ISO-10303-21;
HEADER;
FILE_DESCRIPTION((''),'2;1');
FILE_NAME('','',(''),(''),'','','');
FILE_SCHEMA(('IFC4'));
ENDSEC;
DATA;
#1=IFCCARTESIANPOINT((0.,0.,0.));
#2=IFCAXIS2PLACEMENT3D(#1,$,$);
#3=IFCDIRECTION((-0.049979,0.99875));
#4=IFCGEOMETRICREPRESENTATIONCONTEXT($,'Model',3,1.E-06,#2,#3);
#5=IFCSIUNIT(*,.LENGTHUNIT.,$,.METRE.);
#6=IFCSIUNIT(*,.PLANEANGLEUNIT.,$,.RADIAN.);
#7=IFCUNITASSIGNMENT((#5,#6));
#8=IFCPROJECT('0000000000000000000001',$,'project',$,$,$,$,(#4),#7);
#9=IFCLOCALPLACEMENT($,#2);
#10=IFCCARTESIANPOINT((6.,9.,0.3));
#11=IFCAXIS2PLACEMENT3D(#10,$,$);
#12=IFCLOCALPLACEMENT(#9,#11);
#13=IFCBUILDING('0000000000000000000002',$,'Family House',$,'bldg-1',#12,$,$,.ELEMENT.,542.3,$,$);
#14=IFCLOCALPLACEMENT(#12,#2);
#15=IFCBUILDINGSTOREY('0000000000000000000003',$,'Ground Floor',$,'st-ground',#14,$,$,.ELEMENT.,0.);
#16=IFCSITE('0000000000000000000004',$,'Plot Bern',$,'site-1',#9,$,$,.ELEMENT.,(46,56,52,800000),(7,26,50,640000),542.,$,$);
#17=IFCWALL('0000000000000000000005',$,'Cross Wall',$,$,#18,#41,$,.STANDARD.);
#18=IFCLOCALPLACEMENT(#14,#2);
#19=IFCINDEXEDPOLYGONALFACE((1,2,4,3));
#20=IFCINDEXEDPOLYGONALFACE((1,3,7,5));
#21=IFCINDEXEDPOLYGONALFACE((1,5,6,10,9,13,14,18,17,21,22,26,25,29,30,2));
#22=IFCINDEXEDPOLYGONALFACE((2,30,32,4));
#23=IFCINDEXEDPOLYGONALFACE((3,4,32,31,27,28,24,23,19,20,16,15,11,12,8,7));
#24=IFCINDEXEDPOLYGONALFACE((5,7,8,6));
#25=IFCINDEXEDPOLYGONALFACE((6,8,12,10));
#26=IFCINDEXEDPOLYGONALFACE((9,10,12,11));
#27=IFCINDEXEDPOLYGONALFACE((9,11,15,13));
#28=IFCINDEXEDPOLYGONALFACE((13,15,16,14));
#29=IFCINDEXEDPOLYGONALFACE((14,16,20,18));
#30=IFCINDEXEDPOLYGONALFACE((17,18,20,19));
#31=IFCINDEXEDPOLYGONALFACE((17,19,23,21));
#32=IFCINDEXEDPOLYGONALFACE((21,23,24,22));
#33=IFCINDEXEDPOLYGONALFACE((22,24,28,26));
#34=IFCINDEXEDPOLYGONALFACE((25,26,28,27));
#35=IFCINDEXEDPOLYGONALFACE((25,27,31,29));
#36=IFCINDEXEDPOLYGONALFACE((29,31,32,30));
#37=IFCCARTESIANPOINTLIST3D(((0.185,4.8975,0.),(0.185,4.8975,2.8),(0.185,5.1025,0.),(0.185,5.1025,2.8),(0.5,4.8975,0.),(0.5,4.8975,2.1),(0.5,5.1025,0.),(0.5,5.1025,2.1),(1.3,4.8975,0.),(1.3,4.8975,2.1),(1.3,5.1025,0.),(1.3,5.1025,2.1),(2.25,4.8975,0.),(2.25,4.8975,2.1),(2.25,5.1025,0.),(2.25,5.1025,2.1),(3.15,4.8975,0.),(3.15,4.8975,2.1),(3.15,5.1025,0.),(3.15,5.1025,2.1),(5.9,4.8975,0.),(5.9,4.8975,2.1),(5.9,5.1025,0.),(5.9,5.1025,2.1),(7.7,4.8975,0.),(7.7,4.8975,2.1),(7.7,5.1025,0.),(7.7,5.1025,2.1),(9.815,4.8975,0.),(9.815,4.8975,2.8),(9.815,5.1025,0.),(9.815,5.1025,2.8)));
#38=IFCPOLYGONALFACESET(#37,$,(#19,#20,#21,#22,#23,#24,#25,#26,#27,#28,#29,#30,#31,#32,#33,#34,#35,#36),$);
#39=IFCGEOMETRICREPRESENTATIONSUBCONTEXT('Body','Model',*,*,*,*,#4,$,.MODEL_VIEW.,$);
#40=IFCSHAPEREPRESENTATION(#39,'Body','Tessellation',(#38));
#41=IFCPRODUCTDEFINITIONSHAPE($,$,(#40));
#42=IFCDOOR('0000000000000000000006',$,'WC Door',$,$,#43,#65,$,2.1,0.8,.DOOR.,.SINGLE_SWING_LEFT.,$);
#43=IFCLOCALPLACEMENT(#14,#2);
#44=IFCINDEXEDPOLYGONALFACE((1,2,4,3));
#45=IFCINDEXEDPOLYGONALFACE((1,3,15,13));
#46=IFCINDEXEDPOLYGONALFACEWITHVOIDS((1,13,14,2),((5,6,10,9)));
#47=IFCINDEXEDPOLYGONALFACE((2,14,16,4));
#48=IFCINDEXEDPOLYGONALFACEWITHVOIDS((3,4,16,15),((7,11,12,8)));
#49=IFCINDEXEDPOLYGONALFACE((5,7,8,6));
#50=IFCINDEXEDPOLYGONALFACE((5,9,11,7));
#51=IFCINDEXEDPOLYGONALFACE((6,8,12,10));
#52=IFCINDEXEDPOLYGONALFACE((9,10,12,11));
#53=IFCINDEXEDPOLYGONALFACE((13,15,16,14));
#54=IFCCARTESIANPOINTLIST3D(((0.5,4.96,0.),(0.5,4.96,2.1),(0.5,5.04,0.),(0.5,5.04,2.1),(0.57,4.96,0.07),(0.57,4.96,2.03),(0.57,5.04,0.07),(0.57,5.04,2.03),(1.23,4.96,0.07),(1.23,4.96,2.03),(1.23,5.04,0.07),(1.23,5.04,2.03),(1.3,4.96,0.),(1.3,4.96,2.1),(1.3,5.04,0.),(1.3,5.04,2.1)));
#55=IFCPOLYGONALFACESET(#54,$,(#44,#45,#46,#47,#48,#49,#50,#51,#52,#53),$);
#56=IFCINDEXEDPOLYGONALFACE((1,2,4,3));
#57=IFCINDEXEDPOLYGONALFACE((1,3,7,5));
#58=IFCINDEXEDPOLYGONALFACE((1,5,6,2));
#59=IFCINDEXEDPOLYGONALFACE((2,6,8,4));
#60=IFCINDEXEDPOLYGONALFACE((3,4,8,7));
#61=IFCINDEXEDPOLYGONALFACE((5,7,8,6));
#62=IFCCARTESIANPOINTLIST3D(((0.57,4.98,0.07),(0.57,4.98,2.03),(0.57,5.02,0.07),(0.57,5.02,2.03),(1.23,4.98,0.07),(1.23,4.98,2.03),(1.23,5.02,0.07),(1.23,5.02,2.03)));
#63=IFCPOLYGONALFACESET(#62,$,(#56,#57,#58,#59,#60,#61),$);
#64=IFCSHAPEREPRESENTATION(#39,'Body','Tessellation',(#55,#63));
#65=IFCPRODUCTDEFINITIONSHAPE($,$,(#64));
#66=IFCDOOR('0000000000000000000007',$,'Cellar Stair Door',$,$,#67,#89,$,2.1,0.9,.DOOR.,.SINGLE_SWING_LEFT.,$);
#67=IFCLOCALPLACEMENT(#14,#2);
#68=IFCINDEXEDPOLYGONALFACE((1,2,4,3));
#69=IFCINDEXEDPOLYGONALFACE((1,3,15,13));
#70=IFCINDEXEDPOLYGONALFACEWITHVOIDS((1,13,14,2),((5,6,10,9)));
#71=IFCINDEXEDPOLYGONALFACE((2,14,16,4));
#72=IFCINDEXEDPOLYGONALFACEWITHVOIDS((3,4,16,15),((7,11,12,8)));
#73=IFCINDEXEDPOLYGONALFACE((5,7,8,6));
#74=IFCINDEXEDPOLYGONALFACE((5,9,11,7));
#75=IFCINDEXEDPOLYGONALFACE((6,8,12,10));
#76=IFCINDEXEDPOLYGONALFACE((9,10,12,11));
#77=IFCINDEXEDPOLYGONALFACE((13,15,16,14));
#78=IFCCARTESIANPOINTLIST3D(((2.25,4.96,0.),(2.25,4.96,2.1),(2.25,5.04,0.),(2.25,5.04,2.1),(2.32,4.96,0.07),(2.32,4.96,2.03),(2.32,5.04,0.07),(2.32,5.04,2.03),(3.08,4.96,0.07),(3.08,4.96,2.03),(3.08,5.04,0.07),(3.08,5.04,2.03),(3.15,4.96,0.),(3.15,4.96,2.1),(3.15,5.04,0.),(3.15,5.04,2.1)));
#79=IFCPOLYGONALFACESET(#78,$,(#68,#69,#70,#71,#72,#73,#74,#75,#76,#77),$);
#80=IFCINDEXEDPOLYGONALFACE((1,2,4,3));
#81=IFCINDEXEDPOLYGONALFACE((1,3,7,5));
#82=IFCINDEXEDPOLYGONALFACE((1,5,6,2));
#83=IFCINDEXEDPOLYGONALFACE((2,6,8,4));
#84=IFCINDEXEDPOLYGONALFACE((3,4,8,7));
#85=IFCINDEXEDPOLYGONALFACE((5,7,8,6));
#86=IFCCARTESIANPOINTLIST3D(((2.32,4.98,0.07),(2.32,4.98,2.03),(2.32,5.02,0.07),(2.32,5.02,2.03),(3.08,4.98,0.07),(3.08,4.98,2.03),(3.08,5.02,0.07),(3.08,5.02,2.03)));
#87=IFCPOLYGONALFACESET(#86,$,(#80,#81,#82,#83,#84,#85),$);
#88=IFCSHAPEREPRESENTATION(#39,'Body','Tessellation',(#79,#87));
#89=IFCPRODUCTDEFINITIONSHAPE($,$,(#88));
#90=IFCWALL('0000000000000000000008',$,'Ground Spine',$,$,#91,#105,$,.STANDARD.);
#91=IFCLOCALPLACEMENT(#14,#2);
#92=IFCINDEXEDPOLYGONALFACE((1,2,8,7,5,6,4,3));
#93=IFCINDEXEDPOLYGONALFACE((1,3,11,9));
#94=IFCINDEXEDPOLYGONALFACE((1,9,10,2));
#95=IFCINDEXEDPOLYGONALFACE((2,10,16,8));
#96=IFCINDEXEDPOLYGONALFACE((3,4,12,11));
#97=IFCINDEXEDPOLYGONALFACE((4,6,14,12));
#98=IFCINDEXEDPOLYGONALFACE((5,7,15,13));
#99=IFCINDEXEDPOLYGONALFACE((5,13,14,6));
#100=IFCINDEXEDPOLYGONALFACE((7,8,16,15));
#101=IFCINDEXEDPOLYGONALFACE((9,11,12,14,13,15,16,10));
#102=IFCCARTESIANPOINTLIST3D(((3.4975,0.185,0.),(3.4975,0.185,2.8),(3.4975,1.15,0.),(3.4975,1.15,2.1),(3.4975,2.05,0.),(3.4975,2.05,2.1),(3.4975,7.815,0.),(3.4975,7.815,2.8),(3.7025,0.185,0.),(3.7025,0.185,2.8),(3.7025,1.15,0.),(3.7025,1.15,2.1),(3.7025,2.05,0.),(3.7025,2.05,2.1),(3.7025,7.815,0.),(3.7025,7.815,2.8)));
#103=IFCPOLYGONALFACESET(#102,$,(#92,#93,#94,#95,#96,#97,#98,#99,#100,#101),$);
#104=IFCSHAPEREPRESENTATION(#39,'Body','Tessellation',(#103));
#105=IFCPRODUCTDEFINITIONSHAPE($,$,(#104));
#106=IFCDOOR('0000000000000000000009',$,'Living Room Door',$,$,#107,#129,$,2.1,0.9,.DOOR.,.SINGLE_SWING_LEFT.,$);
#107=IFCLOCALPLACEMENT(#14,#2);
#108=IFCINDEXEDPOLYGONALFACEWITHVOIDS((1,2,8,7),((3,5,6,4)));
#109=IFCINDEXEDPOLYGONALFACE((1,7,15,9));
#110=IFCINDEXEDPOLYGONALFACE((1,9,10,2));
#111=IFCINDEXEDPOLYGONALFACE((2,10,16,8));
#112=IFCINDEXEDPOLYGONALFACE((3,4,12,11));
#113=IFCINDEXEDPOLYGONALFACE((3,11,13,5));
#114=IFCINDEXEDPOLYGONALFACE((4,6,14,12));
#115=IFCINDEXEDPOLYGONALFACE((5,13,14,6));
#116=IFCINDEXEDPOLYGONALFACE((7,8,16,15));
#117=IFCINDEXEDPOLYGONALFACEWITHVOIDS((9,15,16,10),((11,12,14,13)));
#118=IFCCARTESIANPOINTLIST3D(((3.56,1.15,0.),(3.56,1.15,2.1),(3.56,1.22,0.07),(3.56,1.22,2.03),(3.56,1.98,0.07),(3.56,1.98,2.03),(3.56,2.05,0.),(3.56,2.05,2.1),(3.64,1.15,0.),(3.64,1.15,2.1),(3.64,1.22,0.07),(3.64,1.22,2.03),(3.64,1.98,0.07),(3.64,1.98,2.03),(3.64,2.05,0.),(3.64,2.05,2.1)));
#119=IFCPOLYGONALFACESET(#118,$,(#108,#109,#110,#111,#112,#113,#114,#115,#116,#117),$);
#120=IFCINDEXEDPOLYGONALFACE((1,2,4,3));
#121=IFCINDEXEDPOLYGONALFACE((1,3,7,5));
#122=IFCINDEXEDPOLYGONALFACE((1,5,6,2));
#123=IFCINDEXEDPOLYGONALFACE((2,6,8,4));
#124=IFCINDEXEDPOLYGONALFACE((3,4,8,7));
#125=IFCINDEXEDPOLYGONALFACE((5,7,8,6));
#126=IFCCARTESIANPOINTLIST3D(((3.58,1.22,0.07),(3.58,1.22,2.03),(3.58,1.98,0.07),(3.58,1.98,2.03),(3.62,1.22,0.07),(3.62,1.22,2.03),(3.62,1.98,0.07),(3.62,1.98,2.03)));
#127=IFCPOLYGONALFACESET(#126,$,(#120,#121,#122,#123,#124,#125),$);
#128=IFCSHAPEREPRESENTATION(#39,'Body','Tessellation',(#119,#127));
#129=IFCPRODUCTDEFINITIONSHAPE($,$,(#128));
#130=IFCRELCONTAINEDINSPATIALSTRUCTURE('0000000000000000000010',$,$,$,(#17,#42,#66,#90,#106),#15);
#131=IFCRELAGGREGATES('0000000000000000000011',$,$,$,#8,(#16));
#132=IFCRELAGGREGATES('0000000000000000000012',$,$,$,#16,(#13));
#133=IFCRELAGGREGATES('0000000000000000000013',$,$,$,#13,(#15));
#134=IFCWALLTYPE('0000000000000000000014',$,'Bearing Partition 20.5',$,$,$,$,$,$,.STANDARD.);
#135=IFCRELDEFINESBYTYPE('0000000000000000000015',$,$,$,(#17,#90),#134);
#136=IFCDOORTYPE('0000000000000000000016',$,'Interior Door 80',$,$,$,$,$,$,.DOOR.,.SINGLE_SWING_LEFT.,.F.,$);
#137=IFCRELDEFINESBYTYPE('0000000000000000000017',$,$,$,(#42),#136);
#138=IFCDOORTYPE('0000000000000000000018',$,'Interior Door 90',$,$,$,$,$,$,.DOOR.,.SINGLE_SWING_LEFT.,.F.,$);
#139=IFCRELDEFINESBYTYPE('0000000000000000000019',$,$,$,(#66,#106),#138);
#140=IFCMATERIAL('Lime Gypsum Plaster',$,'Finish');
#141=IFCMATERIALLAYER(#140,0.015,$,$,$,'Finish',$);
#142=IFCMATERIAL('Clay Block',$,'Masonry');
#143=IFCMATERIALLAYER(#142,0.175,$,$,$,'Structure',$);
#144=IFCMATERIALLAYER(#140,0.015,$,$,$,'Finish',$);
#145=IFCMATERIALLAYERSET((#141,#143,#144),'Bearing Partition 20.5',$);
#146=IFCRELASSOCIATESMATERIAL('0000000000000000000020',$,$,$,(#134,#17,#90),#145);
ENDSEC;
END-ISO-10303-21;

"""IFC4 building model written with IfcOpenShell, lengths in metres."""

from ifc_helpers import new_model, si_unit, direction, frame, frame_2d, origin, origin_2d, place, context, subcontext, project, spatial, polyline, rectangle, outline, extrude, material, layer, layer_set, layer_usage, type_object, element, fill, save


model = new_model("IFC4")

# Units and contexts
model_context = context("Model", 3, precision=1e-06, world=origin(), true_north=direction((-0.049979, 0.99875)))
body_context = subcontext(model_context, "Body", "Model", "MODEL_VIEW")
ifc_project = project(units=[si_unit("LENGTHUNIT", "METRE"), si_unit("PLANEANGLEUNIT", "RADIAN")], contexts=[model_context])

# Site, building, storey
site_placement = place(None, origin())
site = spatial("IfcSite", under=ifc_project, at=site_placement, Name="Plot Bern", ObjectType="site-1", CompositionType="ELEMENT", RefLatitude=(46, 56, 52, 800000), RefLongitude=(7, 26, 50, 640000), RefElevation=542.0)
building_placement = place(site_placement, frame((6.0, 9.0, 0.3)))
building = spatial("IfcBuilding", under=site, at=building_placement, Name="Family House", ObjectType="bldg-1", CompositionType="ELEMENT", ElevationOfRefHeight=542.3)
storey_placement = place(building_placement, origin())
storey = spatial("IfcBuildingStorey", under=building, at=storey_placement, Name="Ground Floor", ObjectType="st-ground", CompositionType="ELEMENT", Elevation=0.0)

# Shared definitions
ifc_material_1 = material(Name="Lime Gypsum Plaster", Category="Finish")
ifc_material_2 = material(Name="Clay Block", Category="Masonry")

# Wall, openings, doors
ifc_layer_1 = layer(ifc_material_1, 0.015, Category="Finish")
ifc_layer_2 = layer(ifc_material_2, 0.175, Category="Structure")
ifc_layer_3 = layer(ifc_material_1, 0.015, Category="Finish")
ifc_layer_set_1 = layer_set([ifc_layer_1, ifc_layer_2, ifc_layer_3], Name="Bearing Partition 20.5")
ifc_layer_usage_1 = layer_usage(ifc_layer_set_1, "AXIS2", "NEGATIVE", 0.1025)
wall_type_1 = type_object("IfcWallType", Name="Bearing Partition 20.5", PredefinedType="STANDARD", material=ifc_layer_set_1)
wall_1_placement = place(storey_placement, origin())
wall_1 = element("IfcWall", 1, at=wall_1_placement, inside=storey, type_object=wall_type_1, material=ifc_layer_usage_1, Name="Cross Wall", PredefinedType="STANDARD", context=body_context, shape_type="SweptSolid", body=[
    extrude(outline(polyline([(0.185, 4.8975), (9.815, 4.8975), (9.815, 5.1025), (0.185, 5.1025), (0.185, 4.8975)])), origin(), (0.0, 0.0, 1.0), 2.8),
])
opening_1_placement = place(wall_1_placement, frame((2.7, 5.0, 0.0), z_axis=(0.0, 0.0, 1.0), x_axis=(1.0, 0.0, 0.0)))
opening_1 = element("IfcOpeningElement", 2, at=opening_1_placement, cuts=wall_1, PredefinedType="OPENING", context=body_context, shape_type="SweptSolid", body=[
    extrude(rectangle(XDim=0.9, YDim=0.205, at=origin_2d()), origin(), (0.0, 0.0, 1.0), 2.1),
])
opening_2_placement = place(wall_1_placement, frame((6.8, 5.0, 0.0), z_axis=(0.0, 0.0, 1.0), x_axis=(1.0, 0.0, 0.0)))
element("IfcOpeningElement", 3, at=opening_2_placement, cuts=wall_1, PredefinedType="OPENING", context=body_context, shape_type="SweptSolid", body=[
    extrude(rectangle(XDim=1.8, YDim=0.205, at=origin_2d()), origin(), (0.0, 0.0, 1.0), 2.1),
])
opening_3_placement = place(wall_1_placement, frame((0.9, 5.0, 0.0), z_axis=(0.0, 0.0, 1.0), x_axis=(1.0, 0.0, 0.0)))
opening_3 = element("IfcOpeningElement", 4, at=opening_3_placement, cuts=wall_1, PredefinedType="OPENING", context=body_context, shape_type="SweptSolid", body=[
    extrude(rectangle(XDim=0.8, YDim=0.205, at=origin_2d()), origin(), (0.0, 0.0, 1.0), 2.1),
])
door_type_1 = type_object("IfcDoorType", Name="Interior Door 80", OperationType="SINGLE_SWING_LEFT", ParameterTakesPrecedence=False, PredefinedType="DOOR")
door_1_placement = place(opening_3_placement, frame((0.0, 0.0, 0.0), z_axis=(0.0, -1.0, 0.0), x_axis=(1.0, 0.0, 0.0)))
door_1 = element("IfcDoor", 5, at=door_1_placement, inside=storey, type_object=door_type_1, Name="WC Door", OperationType="SINGLE_SWING_LEFT", OverallHeight=2.1, OverallWidth=0.8, PredefinedType="DOOR", context=body_context, shape_type="SweptSolid", body=[
    extrude(outline(polyline([(-0.4, 0.0), (0.4, 0.0), (0.4, 2.1), (-0.4, 2.1), (-0.4, 0.0)]), holes=[polyline([(-0.33, 0.07), (0.33, 0.07), (0.33, 2.03), (-0.33, 2.03), (-0.33, 0.07)])]), frame((0.0, 0.0, -0.04)), (0.0, 0.0, 1.0), 0.08),
    extrude(rectangle(XDim=0.66, YDim=1.96, at=frame_2d((0.0, 1.05))), frame((0.0, 0.0, -0.02)), (0.0, 0.0, 1.0), 0.04),
])
fill(opening_3, door_1)
door_type_2 = type_object("IfcDoorType", Name="Interior Door 90", OperationType="SINGLE_SWING_LEFT", ParameterTakesPrecedence=False, PredefinedType="DOOR")
door_2_placement = place(opening_1_placement, frame((0.0, 0.0, 0.0), z_axis=(0.0, 1.0, 0.0), x_axis=(-1.0, 0.0, 0.0)))
door_2 = element("IfcDoor", 6, at=door_2_placement, inside=storey, type_object=door_type_2, Name="Cellar Stair Door", OperationType="SINGLE_SWING_LEFT", OverallHeight=2.1, OverallWidth=0.9, PredefinedType="DOOR", context=body_context, shape_type="SweptSolid", body=[
    extrude(outline(polyline([(-0.45, 0.0), (0.45, 0.0), (0.45, 2.1), (-0.45, 2.1), (-0.45, 0.0)]), holes=[polyline([(-0.38, 0.07), (0.38, 0.07), (0.38, 2.03), (-0.38, 2.03), (-0.38, 0.07)])]), frame((0.0, 0.0, -0.04)), (0.0, 0.0, 1.0), 0.08),
    extrude(rectangle(XDim=0.76, YDim=1.96, at=frame_2d((0.0, 1.05))), frame((0.0, 0.0, -0.02)), (0.0, 0.0, 1.0), 0.04),
])
fill(opening_1, door_2)

# Wall, opening, door
ifc_layer_usage_2 = layer_usage(ifc_layer_set_1, "AXIS2", "NEGATIVE", 0.1025)
wall_2_placement = place(storey_placement, origin())
wall_2 = element("IfcWall", 7, at=wall_2_placement, inside=storey, type_object=wall_type_1, material=ifc_layer_usage_2, Name="Ground Spine", PredefinedType="STANDARD", context=body_context, shape_type="SweptSolid", body=[
    extrude(outline(polyline([(3.7025, 0.185), (3.7025, 7.815), (3.4975, 7.815), (3.4975, 0.185), (3.7025, 0.185)])), origin(), (0.0, 0.0, 1.0), 2.8),
])
opening_4_placement = place(wall_2_placement, frame((3.6, 1.6, 0.0), z_axis=(0.0, 0.0, 1.0), x_axis=(0.0, 1.0, 0.0)))
opening_4 = element("IfcOpeningElement", 8, at=opening_4_placement, cuts=wall_2, PredefinedType="OPENING", context=body_context, shape_type="SweptSolid", body=[
    extrude(rectangle(XDim=0.9, YDim=0.205, at=origin_2d()), origin(), (0.0, 0.0, 1.0), 2.1),
])
door_3_placement = place(opening_4_placement, frame((0.0, 0.0, 0.0), z_axis=(0.0, -1.0, 0.0), x_axis=(1.0, 0.0, 0.0)))
door_3 = element("IfcDoor", 9, at=door_3_placement, inside=storey, type_object=door_type_2, Name="Living Room Door", OperationType="SINGLE_SWING_LEFT", OverallHeight=2.1, OverallWidth=0.9, PredefinedType="DOOR", context=body_context, shape_type="SweptSolid", body=[
    extrude(outline(polyline([(-0.45, 0.0), (0.45, 0.0), (0.45, 2.1), (-0.45, 2.1), (-0.45, 0.0)]), holes=[polyline([(-0.38, 0.07), (0.38, 0.07), (0.38, 2.03), (-0.38, 2.03), (-0.38, 0.07)])]), frame((0.0, 0.0, -0.04)), (0.0, 0.0, 1.0), 0.08),
    extrude(rectangle(XDim=0.76, YDim=1.96, at=frame_2d((0.0, 1.05))), frame((0.0, 0.0, -0.02)), (0.0, 0.0, 1.0), 0.04),
])
fill(opening_4, door_3)

save(model, "model.ifc")
